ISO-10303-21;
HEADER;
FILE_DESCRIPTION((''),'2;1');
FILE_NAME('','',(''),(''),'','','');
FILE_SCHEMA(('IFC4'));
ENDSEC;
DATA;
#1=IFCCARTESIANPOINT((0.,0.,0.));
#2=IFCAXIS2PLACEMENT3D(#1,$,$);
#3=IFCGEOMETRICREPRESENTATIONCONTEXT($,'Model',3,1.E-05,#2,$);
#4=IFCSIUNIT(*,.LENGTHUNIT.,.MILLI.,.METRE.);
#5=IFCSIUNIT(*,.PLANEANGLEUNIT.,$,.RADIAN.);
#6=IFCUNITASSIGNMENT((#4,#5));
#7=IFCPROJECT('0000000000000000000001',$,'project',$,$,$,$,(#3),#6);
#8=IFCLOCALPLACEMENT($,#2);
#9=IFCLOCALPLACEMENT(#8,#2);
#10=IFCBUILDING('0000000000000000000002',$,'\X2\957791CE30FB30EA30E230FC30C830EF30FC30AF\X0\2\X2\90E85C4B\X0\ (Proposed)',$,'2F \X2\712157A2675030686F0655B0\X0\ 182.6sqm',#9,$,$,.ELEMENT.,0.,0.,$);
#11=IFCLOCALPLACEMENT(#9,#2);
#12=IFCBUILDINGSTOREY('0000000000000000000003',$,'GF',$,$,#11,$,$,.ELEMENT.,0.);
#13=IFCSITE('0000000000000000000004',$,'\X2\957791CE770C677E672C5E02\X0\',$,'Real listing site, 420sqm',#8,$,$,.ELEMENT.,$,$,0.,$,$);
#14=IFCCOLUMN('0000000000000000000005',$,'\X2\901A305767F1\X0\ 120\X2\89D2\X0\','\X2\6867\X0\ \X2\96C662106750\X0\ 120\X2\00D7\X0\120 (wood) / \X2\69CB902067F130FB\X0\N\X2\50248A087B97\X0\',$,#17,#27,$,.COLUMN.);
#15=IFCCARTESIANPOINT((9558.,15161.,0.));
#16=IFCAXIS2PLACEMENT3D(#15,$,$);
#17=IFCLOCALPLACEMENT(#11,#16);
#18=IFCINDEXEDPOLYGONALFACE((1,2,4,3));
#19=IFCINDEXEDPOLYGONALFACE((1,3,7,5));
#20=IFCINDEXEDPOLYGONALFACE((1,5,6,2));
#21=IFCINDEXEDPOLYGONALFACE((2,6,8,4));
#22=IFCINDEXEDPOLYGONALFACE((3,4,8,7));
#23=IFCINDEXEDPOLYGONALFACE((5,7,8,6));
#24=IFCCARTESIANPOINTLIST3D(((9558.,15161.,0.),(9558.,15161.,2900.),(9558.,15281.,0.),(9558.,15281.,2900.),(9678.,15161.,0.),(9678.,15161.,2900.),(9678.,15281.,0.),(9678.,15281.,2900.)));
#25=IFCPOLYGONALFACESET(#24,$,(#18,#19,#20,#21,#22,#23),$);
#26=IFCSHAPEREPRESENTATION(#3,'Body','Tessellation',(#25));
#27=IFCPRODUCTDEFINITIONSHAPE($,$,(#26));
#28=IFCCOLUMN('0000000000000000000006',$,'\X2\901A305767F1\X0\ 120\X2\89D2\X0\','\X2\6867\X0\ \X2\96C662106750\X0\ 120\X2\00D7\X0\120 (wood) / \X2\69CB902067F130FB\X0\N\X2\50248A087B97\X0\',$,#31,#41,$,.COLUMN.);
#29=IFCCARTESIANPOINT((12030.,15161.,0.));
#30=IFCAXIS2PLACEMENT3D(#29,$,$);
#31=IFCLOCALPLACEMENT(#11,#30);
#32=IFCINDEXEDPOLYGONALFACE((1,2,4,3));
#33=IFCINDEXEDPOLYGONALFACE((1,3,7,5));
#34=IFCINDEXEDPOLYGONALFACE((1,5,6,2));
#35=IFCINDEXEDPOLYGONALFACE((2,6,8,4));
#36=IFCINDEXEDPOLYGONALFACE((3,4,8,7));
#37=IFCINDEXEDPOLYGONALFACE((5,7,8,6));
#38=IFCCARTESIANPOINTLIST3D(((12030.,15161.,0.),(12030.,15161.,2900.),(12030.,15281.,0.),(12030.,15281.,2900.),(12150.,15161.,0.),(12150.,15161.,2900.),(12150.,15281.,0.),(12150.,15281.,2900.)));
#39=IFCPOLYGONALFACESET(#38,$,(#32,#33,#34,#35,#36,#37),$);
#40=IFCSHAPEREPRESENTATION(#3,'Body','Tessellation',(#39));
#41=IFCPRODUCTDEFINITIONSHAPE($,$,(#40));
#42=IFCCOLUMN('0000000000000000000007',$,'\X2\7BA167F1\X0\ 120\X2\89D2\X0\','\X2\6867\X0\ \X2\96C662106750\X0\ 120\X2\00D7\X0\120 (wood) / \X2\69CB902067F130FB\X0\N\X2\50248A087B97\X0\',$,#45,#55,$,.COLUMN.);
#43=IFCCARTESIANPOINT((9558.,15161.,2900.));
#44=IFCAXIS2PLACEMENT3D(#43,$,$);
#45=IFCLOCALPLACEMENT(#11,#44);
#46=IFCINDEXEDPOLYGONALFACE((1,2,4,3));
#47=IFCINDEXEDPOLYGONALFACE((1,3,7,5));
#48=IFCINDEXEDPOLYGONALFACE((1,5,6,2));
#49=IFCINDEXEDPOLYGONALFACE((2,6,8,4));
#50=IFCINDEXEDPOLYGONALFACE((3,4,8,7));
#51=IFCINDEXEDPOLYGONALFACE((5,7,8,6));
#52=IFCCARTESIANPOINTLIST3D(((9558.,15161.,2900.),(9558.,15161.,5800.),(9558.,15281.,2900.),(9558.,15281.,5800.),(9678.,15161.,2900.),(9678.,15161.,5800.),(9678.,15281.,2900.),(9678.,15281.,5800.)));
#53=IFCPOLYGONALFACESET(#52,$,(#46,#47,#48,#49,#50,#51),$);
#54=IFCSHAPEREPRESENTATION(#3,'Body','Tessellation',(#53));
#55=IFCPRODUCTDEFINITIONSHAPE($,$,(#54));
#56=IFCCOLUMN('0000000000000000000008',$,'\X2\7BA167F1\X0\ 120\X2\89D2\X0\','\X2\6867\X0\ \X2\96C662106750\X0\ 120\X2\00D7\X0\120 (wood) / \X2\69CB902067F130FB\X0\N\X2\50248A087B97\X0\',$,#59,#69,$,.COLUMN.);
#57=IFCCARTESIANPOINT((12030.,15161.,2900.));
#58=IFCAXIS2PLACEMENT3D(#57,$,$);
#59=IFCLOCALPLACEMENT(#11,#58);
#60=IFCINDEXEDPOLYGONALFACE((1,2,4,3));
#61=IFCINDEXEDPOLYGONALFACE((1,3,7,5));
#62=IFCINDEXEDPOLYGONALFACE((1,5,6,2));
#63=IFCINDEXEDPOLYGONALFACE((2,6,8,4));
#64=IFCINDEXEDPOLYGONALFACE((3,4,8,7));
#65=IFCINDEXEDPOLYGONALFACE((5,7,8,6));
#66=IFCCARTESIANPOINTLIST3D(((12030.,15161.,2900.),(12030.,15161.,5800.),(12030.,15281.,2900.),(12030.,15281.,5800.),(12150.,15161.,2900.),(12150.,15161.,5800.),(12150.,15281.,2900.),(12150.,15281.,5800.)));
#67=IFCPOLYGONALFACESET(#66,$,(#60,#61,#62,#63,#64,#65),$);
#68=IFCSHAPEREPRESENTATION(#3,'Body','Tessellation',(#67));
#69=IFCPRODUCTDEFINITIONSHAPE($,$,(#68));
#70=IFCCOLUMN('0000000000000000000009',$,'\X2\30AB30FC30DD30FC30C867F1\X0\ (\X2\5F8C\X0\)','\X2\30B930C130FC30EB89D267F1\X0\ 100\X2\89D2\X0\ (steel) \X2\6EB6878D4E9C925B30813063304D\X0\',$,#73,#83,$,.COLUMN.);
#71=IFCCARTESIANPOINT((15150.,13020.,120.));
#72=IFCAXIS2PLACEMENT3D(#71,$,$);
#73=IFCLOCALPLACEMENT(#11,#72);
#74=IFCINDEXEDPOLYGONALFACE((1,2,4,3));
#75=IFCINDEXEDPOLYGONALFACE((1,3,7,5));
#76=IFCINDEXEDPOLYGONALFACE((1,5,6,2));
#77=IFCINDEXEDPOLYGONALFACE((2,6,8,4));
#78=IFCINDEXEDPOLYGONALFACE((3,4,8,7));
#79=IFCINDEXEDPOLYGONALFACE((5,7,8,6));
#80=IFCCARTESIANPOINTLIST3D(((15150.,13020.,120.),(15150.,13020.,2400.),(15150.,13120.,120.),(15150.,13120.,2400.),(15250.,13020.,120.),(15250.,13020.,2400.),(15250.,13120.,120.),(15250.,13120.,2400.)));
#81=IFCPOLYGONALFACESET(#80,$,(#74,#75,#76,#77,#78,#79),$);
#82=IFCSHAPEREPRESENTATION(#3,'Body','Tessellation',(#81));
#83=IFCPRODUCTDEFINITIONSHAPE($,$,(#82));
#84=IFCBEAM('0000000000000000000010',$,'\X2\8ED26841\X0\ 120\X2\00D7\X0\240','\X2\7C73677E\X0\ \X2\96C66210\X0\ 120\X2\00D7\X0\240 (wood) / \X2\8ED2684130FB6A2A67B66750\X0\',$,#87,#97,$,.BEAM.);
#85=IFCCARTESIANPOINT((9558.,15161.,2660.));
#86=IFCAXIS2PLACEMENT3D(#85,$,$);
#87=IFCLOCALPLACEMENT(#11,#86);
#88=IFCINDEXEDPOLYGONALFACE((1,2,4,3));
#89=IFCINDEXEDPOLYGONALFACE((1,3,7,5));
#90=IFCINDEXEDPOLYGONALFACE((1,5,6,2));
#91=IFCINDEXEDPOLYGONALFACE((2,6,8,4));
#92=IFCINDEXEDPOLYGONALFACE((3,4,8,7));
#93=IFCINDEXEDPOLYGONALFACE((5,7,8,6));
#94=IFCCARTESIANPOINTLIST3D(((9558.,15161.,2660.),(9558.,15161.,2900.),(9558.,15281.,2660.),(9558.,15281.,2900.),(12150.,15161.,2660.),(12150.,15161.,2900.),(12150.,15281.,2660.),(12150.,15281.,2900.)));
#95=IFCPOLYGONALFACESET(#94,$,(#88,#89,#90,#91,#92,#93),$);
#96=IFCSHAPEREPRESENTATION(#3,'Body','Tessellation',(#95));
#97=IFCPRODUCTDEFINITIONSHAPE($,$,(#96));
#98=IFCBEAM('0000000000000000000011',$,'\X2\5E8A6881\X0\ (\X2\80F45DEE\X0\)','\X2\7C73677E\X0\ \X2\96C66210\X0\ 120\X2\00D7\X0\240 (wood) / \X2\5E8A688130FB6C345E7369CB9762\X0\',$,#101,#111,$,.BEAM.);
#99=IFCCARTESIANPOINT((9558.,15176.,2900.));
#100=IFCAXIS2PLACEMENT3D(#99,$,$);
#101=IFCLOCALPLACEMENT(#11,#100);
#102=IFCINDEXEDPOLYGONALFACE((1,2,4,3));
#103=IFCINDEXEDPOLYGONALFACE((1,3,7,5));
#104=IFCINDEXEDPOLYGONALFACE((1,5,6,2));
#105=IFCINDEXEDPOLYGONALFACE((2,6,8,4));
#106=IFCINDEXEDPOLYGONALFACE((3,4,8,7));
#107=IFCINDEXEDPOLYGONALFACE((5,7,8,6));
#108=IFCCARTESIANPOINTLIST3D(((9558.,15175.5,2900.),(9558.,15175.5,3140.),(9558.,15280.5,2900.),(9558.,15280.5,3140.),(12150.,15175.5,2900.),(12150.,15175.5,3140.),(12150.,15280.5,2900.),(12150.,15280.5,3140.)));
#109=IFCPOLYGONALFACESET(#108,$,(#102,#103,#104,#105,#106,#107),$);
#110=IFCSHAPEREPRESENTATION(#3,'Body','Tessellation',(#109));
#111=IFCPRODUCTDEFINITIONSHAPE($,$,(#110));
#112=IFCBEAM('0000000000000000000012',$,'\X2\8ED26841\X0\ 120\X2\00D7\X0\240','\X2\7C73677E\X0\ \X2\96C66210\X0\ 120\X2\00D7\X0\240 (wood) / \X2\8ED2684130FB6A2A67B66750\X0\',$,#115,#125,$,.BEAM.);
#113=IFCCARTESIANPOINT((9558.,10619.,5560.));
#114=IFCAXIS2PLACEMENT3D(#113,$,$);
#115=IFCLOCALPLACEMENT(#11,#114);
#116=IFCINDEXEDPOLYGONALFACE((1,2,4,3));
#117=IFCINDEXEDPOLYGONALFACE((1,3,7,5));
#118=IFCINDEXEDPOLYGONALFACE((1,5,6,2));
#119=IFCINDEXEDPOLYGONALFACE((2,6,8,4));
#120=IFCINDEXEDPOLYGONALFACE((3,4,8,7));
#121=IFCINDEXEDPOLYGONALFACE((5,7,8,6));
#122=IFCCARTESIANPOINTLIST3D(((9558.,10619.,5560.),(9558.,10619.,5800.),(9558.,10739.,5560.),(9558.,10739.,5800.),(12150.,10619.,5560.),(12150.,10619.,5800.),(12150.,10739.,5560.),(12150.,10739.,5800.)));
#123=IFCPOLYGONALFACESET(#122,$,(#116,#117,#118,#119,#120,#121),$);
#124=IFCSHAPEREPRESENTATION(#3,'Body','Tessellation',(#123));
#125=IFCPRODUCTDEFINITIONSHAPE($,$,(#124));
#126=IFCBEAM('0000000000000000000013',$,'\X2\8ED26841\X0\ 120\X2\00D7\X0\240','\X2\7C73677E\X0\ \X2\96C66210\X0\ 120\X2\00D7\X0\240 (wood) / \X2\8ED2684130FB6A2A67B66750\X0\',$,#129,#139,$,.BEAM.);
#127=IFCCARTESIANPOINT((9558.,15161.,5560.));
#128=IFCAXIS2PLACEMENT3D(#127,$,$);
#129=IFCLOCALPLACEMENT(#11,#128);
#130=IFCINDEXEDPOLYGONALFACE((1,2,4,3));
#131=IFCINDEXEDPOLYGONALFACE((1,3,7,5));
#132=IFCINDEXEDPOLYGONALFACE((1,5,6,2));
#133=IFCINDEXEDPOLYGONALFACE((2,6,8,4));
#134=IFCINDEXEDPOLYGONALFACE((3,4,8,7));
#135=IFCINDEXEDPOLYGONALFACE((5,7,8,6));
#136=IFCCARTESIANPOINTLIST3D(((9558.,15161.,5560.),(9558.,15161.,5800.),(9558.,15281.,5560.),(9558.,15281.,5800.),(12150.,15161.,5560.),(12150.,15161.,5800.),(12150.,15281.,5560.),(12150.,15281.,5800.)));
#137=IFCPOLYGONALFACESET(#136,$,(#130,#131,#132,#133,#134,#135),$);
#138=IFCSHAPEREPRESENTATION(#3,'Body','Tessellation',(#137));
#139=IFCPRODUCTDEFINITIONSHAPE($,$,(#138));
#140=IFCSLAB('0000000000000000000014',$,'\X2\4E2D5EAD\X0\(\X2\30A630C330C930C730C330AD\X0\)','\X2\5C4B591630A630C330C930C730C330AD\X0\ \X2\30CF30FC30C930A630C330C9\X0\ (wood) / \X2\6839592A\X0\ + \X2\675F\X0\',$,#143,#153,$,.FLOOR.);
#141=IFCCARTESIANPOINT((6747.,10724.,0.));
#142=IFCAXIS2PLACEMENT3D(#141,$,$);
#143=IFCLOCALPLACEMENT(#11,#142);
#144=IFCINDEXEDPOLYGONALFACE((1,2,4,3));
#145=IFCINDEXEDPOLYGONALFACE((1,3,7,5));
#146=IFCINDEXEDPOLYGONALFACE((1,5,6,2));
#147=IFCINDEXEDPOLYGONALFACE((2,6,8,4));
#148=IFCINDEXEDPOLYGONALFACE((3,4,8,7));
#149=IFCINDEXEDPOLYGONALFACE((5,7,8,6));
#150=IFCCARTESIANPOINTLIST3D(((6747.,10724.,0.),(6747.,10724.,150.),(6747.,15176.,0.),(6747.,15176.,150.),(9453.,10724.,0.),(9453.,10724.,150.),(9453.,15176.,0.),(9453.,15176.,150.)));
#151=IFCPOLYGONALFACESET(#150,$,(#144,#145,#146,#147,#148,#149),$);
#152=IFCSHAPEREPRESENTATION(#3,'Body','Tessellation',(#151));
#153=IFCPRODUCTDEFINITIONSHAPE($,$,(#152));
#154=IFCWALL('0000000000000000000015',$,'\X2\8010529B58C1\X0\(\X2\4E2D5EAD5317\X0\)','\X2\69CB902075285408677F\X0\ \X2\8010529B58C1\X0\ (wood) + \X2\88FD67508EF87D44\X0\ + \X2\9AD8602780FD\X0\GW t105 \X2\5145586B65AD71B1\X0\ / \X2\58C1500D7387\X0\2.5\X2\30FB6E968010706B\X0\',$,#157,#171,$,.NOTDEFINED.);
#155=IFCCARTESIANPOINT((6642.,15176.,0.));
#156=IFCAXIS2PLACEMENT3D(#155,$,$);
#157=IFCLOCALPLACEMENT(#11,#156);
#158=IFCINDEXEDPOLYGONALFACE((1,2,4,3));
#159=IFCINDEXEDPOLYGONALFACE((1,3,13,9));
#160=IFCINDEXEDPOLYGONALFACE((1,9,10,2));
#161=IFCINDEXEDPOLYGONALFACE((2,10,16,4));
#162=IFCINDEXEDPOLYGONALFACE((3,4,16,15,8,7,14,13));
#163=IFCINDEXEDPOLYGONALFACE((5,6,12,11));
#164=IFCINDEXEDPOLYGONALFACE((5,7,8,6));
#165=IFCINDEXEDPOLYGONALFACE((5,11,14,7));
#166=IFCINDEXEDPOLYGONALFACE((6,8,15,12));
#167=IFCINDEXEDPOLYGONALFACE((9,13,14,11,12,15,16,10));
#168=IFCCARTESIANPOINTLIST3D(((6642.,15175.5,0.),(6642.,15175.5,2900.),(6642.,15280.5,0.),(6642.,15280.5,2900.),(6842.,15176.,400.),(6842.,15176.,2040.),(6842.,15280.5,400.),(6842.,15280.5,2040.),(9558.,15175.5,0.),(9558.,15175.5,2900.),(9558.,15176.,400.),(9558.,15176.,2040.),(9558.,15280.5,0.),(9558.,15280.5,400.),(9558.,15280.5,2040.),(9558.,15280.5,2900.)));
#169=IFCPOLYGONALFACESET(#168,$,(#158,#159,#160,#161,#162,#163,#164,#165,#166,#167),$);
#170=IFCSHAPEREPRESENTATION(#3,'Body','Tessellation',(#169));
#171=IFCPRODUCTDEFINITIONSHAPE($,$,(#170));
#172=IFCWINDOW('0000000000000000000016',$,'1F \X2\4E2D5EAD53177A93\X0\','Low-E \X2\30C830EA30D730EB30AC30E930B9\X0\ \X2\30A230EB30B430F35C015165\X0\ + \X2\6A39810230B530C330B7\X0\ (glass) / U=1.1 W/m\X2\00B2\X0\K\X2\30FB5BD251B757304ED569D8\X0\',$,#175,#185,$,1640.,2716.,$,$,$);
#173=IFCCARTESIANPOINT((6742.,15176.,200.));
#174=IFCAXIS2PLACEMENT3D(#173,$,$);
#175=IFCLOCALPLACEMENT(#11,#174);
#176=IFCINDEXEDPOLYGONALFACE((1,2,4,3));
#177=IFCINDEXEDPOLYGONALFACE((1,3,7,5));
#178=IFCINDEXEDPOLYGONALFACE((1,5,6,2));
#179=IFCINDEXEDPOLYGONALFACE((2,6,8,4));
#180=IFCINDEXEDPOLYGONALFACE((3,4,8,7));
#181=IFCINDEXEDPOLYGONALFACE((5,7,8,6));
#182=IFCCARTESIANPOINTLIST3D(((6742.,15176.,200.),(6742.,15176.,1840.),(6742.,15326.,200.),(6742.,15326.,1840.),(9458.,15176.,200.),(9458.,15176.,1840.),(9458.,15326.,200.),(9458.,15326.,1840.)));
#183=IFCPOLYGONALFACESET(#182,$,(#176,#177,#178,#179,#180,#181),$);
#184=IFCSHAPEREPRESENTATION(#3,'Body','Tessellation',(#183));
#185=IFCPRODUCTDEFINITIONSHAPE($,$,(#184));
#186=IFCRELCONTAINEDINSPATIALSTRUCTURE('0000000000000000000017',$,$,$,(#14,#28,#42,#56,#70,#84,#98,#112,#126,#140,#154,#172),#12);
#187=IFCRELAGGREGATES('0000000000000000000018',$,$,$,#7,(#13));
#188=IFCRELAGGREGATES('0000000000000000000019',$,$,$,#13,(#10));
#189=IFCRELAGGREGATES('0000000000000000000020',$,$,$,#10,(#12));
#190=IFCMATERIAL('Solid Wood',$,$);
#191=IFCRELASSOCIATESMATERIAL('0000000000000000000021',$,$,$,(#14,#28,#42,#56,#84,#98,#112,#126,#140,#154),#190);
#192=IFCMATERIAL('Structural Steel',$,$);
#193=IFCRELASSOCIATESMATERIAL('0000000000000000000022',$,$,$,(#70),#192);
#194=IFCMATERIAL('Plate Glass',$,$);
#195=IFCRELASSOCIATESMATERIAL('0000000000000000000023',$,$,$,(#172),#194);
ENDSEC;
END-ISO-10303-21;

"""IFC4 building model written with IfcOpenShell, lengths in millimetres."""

from ifc_helpers import new_model, si_unit, frame, frame_2d, origin, place, context, project, spatial, rectangle, extrude, material, element, fill, save


model = new_model("IFC4")

# Units and contexts
model_context = context("Model", 3, precision=1e-05, world=origin())
ifc_project = project(units=[si_unit("LENGTHUNIT", "METRE", prefix="MILLI"), si_unit("PLANEANGLEUNIT", "RADIAN")], contexts=[model_context])

# Site, building, storey
site_placement = place(None, origin())
site = spatial("IfcSite", under=ifc_project, at=site_placement, Name="長野県松本市", ObjectType="Real listing site, 420sqm", CompositionType="ELEMENT", RefElevation=0.0)
building_placement = place(site_placement, origin())
building = spatial("IfcBuilding", under=site, at=building_placement, Name="長野・リモートワーク2部屋 (Proposed)", ObjectType="2F 無垢材と漆喰 182.6sqm", CompositionType="ELEMENT", ElevationOfRefHeight=0.0, ElevationOfTerrain=0.0)
storey_placement = place(building_placement, origin())
storey = spatial("IfcBuildingStorey", under=building, at=storey_placement, Name="GF", CompositionType="ELEMENT", Elevation=0.0)

# Columns
ifc_material_1 = material(Name="Solid Wood")
column_1_placement = place(storey_placement, frame((9558.0, 15161.0, 0.0)))
element("IfcColumn", 1, at=column_1_placement, inside=storey, material=ifc_material_1, Name="通し柱 120角", Description="桧 集成材 120×120 (wood) / 構造柱・N値計算", PredefinedType="COLUMN", context=model_context, shape_type="SweptSolid", body=[
    extrude(rectangle(XDim=120.0, YDim=120.0, at=frame_2d((60.0, 60.0))), frame((9558.0, 15161.0, 0.0)), (0.0, 0.0, 1.0), 2900.0),
])
column_2_placement = place(storey_placement, frame((12030.0, 15161.0, 0.0)))
element("IfcColumn", 2, at=column_2_placement, inside=storey, material=ifc_material_1, Name="通し柱 120角", Description="桧 集成材 120×120 (wood) / 構造柱・N値計算", PredefinedType="COLUMN", context=model_context, shape_type="SweptSolid", body=[
    extrude(rectangle(XDim=120.0, YDim=120.0, at=frame_2d((60.0, 60.0))), frame((12030.0, 15161.0, 0.0)), (0.0, 0.0, 1.0), 2900.0),
])
column_3_placement = place(storey_placement, frame((9558.0, 15161.0, 2900.0)))
element("IfcColumn", 3, at=column_3_placement, inside=storey, material=ifc_material_1, Name="管柱 120角", Description="桧 集成材 120×120 (wood) / 構造柱・N値計算", PredefinedType="COLUMN", context=model_context, shape_type="SweptSolid", body=[
    extrude(rectangle(XDim=120.0, YDim=120.0, at=frame_2d((60.0, 60.0))), frame((9558.0, 15161.0, 2900.0)), (0.0, 0.0, 1.0), 2900.0),
])
column_4_placement = place(storey_placement, frame((12030.0, 15161.0, 2900.0)))
element("IfcColumn", 4, at=column_4_placement, inside=storey, material=ifc_material_1, Name="管柱 120角", Description="桧 集成材 120×120 (wood) / 構造柱・N値計算", PredefinedType="COLUMN", context=model_context, shape_type="SweptSolid", body=[
    extrude(rectangle(XDim=120.0, YDim=120.0, at=frame_2d((60.0, 60.0))), frame((12030.0, 15161.0, 2900.0)), (0.0, 0.0, 1.0), 2900.0),
])
ifc_material_2 = material(Name="Structural Steel")
column_5_placement = place(storey_placement, frame((15150.0, 13020.0, 120.0)))
element("IfcColumn", 5, at=column_5_placement, inside=storey, material=ifc_material_2, Name="カーポート柱 (後)", Description="スチール角柱 100角 (steel) 溶融亜鉛めっき", PredefinedType="COLUMN", context=model_context, shape_type="SweptSolid", body=[
    extrude(rectangle(XDim=100.0, YDim=100.0, at=frame_2d((50.0, 50.0))), frame((15150.0, 13020.0, 120.0)), (0.0, 0.0, 1.0), 2280.0),
])

# Beams
beam_1_placement = place(storey_placement, frame((9558.0, 15161.0, 2660.0)))
element("IfcBeam", 6, at=beam_1_placement, inside=storey, material=ifc_material_1, Name="軒桁 120×240", Description="米松 集成 120×240 (wood) / 軒桁・横架材", PredefinedType="BEAM", context=model_context, shape_type="SweptSolid", body=[
    extrude(rectangle(XDim=2592.0, YDim=120.0, at=frame_2d((1296.0, 60.0))), frame((9558.0, 15161.0, 2660.0)), (0.0, 0.0, 1.0), 240.0),
])
beam_2_placement = place(storey_placement, frame((9558.0, 15176.0, 2900.0)))
element("IfcBeam", 7, at=beam_2_placement, inside=storey, material=ifc_material_1, Name="床梁 (胴差)", Description="米松 集成 120×240 (wood) / 床梁・水平構面", PredefinedType="BEAM", context=model_context, shape_type="SweptSolid", body=[
    extrude(rectangle(XDim=2592.0, YDim=105.0, at=frame_2d((1296.0, 52.0))), frame((9558.0, 15176.0, 2900.0)), (0.0, 0.0, 1.0), 240.0),
])
beam_3_placement = place(storey_placement, frame((9558.0, 10619.0, 5560.0)))
element("IfcBeam", 8, at=beam_3_placement, inside=storey, material=ifc_material_1, Name="軒桁 120×240", Description="米松 集成 120×240 (wood) / 軒桁・横架材", PredefinedType="BEAM", context=model_context, shape_type="SweptSolid", body=[
    extrude(rectangle(XDim=2592.0, YDim=120.0, at=frame_2d((1296.0, 60.0))), frame((9558.0, 10619.0, 5560.0)), (0.0, 0.0, 1.0), 240.0),
])
beam_4_placement = place(storey_placement, frame((9558.0, 15161.0, 5560.0)))
element("IfcBeam", 9, at=beam_4_placement, inside=storey, material=ifc_material_1, Name="軒桁 120×240", Description="米松 集成 120×240 (wood) / 軒桁・横架材", PredefinedType="BEAM", context=model_context, shape_type="SweptSolid", body=[
    extrude(rectangle(XDim=2592.0, YDim=120.0, at=frame_2d((1296.0, 60.0))), frame((9558.0, 15161.0, 5560.0)), (0.0, 0.0, 1.0), 240.0),
])

# Slab
slab_placement = place(storey_placement, frame((6747.0, 10724.0, 0.0)))
element("IfcSlab", 10, at=slab_placement, inside=storey, material=ifc_material_1, Name="中庭(ウッドデッキ)", Description="屋外ウッドデッキ ハードウッド (wood) / 根太 + 束", PredefinedType="FLOOR", context=model_context, shape_type="SweptSolid", body=[
    extrude(rectangle(XDim=2706.0, YDim=4452.0, at=frame_2d((1353.0, 2226.0))), frame((6747.0, 10724.0, 0.0)), (0.0, 0.0, 1.0), 150.0),
])

# Wall, opening, window
wall_1_placement = place(storey_placement, frame((6642.0, 15176.0, 0.0)))
wall_1 = element("IfcWall", 11, at=wall_1_placement, inside=storey, material=ifc_material_1, Name="耐力壁(中庭北)", Description="構造用合板 耐力壁 (wood) + 製材軸組 + 高性能GW t105 充填断熱 / 壁倍率2.5・準耐火", PredefinedType="NOTDEFINED", context=model_context, shape_type="SweptSolid", body=[
    extrude(rectangle(XDim=2916.0, YDim=105.0, at=frame_2d((1458.0, 52.0))), frame((6642.0, 15176.0, 0.0)), (0.0, 0.0, 1.0), 2900.0),
])
opening_1_placement = place(storey_placement, frame((6742.0, 15176.0, 200.0)))
opening_1 = element("IfcOpeningElement", 12, at=opening_1_placement, cuts=wall_1, PredefinedType="NOTDEFINED", context=model_context, shape_type="SweptSolid", body=[
    extrude(rectangle(XDim=2716.0, YDim=150.0, at=frame_2d((1358.0, 75.0))), frame((6742.0, 15176.0, 200.0)), (0.0, 0.0, 1.0), 1640.0),
])
ifc_material_3 = material(Name="Plate Glass")
window_1_placement = place(storey_placement, frame((6742.0, 15176.0, 200.0)))
window_1 = element("IfcWindow", 13, at=window_1_placement, inside=storey, material=ifc_material_3, Name="1F 中庭北窓", Description="Low-E トリプルガラス アルゴン封入 + 樹脂サッシ (glass) / U=1.1 W/m²K・寒冷地仕様", OverallHeight=1640.0, OverallWidth=2716.0, context=model_context, shape_type="SweptSolid", body=[
    extrude(rectangle(XDim=2716.0, YDim=150.0, at=frame_2d((1358.0, 75.0))), frame((6742.0, 15176.0, 200.0)), (0.0, 0.0, 1.0), 1640.0),
])
fill(opening_1, window_1)

save(model, "model.ifc")
